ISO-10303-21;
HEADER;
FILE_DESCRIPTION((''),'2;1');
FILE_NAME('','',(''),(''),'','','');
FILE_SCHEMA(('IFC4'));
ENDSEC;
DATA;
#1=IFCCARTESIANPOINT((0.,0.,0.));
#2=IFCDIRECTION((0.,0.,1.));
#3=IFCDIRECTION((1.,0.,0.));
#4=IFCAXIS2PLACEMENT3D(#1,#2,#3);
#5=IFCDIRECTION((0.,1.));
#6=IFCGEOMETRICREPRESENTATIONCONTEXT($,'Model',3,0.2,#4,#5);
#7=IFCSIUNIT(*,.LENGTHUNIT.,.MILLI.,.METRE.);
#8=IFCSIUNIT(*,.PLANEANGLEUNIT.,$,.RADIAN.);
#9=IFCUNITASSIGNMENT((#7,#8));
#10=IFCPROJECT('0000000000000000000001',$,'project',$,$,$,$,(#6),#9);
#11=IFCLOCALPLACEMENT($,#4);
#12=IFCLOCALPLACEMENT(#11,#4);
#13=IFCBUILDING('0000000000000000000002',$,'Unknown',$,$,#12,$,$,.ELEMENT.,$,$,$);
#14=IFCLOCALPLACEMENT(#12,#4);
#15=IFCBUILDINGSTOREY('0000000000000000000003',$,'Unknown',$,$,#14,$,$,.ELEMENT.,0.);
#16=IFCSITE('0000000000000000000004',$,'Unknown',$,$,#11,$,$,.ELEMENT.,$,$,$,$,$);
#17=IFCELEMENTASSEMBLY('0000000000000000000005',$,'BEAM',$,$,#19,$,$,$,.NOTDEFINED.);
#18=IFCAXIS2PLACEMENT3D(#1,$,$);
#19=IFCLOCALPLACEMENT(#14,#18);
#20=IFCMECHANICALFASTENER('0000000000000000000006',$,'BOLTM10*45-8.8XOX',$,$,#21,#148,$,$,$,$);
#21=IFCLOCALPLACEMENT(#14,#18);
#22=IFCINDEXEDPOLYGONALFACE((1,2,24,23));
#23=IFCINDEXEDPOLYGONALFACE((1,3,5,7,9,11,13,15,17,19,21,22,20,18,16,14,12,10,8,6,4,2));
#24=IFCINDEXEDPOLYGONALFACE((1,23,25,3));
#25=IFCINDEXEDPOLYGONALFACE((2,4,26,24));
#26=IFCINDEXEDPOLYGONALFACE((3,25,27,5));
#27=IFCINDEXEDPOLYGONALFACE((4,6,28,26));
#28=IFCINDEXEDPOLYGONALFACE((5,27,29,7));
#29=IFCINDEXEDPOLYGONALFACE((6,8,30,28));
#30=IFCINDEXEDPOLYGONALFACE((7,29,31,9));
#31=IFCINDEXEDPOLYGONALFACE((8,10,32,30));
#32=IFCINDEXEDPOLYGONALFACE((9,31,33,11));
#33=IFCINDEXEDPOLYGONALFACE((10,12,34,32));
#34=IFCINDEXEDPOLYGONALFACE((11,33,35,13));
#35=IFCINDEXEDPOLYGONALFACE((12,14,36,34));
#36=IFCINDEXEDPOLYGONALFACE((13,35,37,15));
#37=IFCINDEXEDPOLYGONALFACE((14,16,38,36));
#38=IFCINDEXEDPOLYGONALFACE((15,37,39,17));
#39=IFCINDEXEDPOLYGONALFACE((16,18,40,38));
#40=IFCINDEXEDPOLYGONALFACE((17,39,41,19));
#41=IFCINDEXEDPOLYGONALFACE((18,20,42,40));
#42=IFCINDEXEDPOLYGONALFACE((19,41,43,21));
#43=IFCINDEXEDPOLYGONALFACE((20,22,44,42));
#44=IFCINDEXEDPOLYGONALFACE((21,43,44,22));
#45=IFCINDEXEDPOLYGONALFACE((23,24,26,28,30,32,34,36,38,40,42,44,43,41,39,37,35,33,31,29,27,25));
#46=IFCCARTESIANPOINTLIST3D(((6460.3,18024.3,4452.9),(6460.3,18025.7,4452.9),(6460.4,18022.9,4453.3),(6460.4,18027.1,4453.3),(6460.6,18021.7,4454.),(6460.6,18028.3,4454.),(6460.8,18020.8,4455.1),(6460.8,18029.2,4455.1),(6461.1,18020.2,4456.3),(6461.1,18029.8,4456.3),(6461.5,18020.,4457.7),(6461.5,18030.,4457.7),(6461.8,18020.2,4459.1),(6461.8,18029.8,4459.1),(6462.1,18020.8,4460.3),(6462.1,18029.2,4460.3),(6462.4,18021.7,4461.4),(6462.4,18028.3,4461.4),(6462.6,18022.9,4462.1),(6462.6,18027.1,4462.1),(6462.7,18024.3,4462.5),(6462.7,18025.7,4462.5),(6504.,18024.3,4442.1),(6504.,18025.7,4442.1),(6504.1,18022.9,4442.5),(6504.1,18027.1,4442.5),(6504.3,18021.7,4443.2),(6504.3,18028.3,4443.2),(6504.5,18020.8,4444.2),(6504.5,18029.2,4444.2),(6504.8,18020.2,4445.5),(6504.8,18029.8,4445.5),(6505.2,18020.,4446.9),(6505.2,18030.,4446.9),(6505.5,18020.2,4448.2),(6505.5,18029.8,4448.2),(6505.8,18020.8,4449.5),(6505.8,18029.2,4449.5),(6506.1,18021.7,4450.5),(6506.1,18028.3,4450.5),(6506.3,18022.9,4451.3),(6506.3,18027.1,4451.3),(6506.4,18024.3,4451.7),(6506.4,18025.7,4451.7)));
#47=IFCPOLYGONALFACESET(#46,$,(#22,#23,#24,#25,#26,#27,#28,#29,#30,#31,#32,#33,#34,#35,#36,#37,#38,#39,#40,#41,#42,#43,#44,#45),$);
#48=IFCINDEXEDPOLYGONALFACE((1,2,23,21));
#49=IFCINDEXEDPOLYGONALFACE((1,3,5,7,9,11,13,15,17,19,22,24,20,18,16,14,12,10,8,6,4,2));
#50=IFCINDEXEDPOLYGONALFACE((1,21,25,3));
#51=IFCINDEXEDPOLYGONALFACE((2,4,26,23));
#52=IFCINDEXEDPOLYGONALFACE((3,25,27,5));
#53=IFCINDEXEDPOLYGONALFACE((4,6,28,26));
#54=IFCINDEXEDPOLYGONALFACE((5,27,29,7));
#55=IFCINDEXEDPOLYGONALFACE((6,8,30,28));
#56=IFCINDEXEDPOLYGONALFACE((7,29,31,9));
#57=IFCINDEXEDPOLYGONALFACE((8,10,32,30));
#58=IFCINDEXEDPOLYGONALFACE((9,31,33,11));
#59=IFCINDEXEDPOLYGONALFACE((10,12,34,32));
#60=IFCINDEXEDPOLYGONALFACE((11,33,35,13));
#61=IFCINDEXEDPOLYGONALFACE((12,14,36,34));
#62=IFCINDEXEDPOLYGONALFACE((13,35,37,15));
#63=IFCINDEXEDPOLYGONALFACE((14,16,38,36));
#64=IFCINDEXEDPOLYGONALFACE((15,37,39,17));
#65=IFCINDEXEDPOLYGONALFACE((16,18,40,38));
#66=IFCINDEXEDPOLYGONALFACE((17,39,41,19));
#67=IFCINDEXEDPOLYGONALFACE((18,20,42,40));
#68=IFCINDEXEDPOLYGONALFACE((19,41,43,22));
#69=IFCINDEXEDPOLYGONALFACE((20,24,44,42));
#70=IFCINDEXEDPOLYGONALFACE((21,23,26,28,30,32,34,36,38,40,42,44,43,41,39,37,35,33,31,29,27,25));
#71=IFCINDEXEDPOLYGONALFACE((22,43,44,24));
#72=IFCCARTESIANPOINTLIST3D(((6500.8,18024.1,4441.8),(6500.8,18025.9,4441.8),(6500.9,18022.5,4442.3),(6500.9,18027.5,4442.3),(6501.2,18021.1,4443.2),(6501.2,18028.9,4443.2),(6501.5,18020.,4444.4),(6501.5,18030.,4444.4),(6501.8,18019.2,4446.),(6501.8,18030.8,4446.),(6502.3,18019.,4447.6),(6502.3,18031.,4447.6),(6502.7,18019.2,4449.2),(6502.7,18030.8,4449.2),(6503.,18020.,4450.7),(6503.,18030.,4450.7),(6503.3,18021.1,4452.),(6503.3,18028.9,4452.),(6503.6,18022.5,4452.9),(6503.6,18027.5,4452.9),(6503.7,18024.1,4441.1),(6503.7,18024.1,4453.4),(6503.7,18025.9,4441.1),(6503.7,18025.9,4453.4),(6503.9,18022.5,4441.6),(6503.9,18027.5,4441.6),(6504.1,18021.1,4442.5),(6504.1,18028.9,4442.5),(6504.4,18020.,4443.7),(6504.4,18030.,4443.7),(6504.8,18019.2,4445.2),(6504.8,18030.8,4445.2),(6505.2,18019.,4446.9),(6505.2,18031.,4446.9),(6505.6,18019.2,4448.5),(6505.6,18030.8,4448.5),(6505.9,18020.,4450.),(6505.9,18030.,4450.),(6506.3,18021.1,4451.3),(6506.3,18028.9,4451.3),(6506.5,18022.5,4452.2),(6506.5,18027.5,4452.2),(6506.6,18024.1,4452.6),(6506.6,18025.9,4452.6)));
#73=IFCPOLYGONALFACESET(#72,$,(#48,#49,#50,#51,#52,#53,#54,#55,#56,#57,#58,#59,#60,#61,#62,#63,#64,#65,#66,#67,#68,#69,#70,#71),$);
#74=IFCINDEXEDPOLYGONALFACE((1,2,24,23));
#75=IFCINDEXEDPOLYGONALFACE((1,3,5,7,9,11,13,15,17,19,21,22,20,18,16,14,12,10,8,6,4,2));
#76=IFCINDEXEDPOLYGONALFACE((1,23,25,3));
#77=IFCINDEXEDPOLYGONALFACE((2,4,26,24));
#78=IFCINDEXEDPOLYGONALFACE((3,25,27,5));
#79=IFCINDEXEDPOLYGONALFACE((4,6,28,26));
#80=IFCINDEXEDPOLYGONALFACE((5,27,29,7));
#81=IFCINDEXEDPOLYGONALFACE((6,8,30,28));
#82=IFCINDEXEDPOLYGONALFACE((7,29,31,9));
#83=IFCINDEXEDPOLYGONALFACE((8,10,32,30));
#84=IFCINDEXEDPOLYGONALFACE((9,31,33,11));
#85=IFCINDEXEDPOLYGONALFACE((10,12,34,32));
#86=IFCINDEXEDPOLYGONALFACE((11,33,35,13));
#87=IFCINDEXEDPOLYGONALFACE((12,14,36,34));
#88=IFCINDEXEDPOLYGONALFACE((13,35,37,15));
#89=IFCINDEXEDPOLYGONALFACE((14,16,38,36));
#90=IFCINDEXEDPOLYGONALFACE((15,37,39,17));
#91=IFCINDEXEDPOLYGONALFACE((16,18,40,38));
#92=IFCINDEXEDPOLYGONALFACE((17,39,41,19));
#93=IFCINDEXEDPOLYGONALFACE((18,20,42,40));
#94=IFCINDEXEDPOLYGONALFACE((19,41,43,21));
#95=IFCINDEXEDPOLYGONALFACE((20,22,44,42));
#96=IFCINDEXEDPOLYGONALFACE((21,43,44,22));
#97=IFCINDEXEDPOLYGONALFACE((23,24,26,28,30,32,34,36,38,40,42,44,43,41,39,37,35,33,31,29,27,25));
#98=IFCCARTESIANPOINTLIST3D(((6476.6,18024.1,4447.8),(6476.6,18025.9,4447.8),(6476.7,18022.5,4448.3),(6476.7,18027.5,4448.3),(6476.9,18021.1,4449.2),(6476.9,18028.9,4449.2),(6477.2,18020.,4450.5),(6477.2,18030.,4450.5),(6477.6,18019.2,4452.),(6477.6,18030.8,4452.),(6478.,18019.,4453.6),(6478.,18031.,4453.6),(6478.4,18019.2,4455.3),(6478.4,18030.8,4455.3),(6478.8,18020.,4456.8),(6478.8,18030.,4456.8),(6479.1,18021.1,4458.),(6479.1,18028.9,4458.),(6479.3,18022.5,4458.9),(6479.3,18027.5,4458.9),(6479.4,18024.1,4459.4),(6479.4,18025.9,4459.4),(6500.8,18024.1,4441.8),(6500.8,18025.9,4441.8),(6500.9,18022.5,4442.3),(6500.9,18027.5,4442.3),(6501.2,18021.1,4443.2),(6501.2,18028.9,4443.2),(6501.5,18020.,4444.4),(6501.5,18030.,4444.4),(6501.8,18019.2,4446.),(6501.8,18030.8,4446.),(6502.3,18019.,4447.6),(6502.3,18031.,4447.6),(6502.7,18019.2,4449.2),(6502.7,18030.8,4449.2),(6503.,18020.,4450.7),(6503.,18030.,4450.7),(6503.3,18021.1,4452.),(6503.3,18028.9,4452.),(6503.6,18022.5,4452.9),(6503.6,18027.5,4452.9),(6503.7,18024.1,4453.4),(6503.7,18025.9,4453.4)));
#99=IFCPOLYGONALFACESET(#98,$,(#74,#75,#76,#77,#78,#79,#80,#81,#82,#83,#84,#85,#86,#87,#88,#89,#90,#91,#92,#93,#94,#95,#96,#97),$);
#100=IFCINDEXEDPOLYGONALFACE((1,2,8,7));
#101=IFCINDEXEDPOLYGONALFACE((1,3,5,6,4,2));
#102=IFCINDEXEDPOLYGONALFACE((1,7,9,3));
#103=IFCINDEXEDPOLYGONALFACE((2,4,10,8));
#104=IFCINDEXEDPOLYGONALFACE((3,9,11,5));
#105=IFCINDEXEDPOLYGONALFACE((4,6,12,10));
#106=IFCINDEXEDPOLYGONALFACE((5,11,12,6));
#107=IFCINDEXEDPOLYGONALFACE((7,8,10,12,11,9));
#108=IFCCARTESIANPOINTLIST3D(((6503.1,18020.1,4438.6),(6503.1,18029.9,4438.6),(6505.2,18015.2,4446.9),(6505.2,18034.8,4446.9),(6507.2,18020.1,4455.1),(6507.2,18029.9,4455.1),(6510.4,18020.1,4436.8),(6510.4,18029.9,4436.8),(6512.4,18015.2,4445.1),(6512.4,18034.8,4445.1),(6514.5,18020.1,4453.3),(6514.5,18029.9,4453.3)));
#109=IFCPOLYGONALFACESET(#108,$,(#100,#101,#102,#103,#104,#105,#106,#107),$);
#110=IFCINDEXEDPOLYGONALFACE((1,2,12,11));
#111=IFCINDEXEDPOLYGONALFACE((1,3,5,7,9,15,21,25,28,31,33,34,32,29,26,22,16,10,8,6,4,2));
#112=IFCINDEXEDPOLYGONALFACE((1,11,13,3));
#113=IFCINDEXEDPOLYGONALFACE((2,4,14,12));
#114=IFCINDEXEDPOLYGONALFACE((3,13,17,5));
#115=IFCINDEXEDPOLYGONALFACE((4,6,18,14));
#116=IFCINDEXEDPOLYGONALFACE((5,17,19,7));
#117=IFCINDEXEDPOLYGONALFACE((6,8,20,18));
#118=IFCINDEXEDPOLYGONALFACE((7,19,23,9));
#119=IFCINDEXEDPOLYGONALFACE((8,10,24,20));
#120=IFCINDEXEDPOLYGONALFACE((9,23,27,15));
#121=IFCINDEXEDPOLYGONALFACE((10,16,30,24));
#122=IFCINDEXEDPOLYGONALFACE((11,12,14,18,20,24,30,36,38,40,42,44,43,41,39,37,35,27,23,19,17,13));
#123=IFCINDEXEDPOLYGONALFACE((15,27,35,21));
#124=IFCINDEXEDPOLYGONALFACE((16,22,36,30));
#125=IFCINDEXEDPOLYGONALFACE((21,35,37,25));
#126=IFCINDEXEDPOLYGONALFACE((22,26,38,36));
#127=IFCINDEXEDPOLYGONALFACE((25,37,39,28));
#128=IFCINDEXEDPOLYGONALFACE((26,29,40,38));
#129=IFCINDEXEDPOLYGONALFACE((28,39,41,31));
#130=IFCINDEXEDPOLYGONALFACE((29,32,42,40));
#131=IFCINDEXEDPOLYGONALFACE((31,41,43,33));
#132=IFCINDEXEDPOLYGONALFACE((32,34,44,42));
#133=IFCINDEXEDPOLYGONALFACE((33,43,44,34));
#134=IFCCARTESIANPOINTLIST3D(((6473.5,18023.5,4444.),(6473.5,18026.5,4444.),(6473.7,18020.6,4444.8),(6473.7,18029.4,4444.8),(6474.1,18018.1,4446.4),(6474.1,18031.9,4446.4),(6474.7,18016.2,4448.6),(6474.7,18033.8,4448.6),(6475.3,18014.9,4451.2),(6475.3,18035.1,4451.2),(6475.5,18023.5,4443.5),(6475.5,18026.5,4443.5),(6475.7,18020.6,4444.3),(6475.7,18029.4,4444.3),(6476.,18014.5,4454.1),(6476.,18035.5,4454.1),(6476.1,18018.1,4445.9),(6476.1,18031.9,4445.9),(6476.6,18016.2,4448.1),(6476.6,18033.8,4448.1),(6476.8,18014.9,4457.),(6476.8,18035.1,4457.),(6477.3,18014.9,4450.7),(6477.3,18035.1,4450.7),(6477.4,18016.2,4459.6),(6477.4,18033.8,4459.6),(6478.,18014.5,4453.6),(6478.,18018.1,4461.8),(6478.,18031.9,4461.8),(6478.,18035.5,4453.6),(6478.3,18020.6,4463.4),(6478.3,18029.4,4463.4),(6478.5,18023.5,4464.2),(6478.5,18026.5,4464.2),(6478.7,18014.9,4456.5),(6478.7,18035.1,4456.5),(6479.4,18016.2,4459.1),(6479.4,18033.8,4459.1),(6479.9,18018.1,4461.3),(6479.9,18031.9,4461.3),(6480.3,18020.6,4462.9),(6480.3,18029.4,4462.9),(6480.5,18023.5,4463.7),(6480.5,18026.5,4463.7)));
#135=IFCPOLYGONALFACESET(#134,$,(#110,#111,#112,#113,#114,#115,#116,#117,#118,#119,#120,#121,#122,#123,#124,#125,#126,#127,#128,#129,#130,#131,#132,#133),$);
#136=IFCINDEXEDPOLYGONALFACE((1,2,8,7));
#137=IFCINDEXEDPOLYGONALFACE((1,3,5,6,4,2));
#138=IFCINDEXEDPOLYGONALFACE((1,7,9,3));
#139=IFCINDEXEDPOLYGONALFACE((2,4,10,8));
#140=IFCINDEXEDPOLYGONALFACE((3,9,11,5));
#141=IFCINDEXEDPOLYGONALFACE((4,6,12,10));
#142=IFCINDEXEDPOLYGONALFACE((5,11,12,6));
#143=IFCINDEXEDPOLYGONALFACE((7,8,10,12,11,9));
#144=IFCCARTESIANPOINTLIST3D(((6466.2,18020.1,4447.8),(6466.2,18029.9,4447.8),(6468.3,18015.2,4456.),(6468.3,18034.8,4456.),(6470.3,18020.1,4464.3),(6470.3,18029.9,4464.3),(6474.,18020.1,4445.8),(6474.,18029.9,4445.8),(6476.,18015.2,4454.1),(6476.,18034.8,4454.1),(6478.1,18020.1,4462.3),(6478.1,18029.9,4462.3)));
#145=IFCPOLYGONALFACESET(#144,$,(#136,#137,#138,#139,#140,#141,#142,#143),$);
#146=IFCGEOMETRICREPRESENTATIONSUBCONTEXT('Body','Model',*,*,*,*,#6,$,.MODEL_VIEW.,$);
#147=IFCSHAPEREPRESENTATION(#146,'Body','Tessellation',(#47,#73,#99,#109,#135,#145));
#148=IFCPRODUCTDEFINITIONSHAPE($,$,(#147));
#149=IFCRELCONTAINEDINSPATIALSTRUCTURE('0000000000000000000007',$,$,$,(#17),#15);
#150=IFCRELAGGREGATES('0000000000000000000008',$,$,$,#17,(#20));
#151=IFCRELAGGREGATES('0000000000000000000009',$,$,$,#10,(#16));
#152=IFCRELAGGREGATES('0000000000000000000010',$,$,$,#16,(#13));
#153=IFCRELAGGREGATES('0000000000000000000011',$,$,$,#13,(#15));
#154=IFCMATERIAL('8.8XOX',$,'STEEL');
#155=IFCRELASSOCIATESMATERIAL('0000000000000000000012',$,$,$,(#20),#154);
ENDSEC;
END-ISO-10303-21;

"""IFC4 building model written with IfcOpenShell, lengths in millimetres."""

from ifc_helpers import new_model, si_unit, direction, frame, origin_with_axes, place, context, subcontext, project, spatial, line, arc, indexed_curve, outline, extrude, source, transform, mapped, material, element, aggregate, save


model = new_model("IFC4")

# Units and contexts
model_context = context("Model", 3, precision=0.2, world=origin_with_axes(), true_north=direction((0.0, 1.0)))
body_context = subcontext(model_context, "Body", "Model", "MODEL_VIEW")
ifc_project = project(units=[si_unit("LENGTHUNIT", "METRE", prefix="MILLI"), si_unit("PLANEANGLEUNIT", "RADIAN")], contexts=[model_context])

# Site, building, storey
site_placement = place(None, origin_with_axes())
site = spatial("IfcSite", under=ifc_project, at=site_placement, Name="Unknown", CompositionType="ELEMENT")
building_placement = place(site_placement, origin_with_axes())
building = spatial("IfcBuilding", under=site, at=building_placement, Name="Unknown", CompositionType="ELEMENT")
storey_placement = place(building_placement, origin_with_axes())
storey = spatial("IfcBuildingStorey", under=building, at=storey_placement, Name="Unknown", CompositionType="ELEMENT", Elevation=0.0)

# Shared definitions
ifc_material_1 = material(Name="8.8XOX", Category="STEEL")

# Element assembly, mechanical fastener
shared_shape_1 = source(origin_with_axes(), body_context, "Body", "SweptSolid", [
    extrude(outline(indexed_curve([(5.0, 0.0), (0.0, 5.0), (-5.0, 0.0), (0.0, -5.0)], segments=[arc(1, 2, 3), arc(3, 4, 1)])), frame((0.0, 0.0, 3.8), z_axis=(0.0, 0.0, -1.0), x_axis=(0.0, 1.0, 0.0)), (0.0, 0.0, 1.0), 45.0),
    extrude(outline(indexed_curve([(6.0, 0.0), (0.0, 6.0), (-6.0, 0.0), (0.0, -6.0)], segments=[arc(1, 2, 3), arc(3, 4, 1)])), frame((0.0, 0.0, 3.8), z_axis=(0.0, 0.0, -1.0), x_axis=(0.0, 1.0, 0.0)), (0.0, 0.0, 1.0), 3.0),
    extrude(outline(indexed_curve([(6.0, 0.0), (0.0, 6.0), (-6.0, 0.0), (0.0, -6.0)], segments=[arc(1, 2, 3), arc(3, 4, 1)])), frame((0.0, 0.0, 0.8), z_axis=(0.0, 0.0, -1.0), x_axis=(0.0, 1.0, 0.0)), (0.0, 0.0, 1.0), 25.0),
    extrude(outline(indexed_curve([(9.8, 0.0), (4.9, 8.5), (-4.9, 8.5), (-9.8, 0.0), (-4.9, -8.5), (4.9, -8.5)], segments=[line(1, 2, 3, 4, 5, 6, 1)])), frame((0.0, 0.0, 11.2), z_axis=(0.0, 0.0, -1.0), x_axis=(0.0, 1.0, 0.0)), (0.0, 0.0, 1.0), 7.5),
    extrude(outline(indexed_curve([(10.5, 0.0), (0.0, 10.5), (-10.5, 0.0), (0.0, -10.5)], segments=[arc(1, 2, 3), arc(3, 4, 1)])), frame((0.0, 0.0, -24.2), z_axis=(0.0, 0.0, -1.0), x_axis=(0.0, 1.0, 0.0)), (0.0, 0.0, 1.0), 2.0),
    extrude(outline(indexed_curve([(9.8, 0.0), (4.9, 8.5), (-4.9, 8.5), (-9.8, 0.0), (-4.9, -8.5), (4.9, -8.5)], segments=[line(1, 2, 3, 4, 5, 6, 1)])), frame((0.0, 0.0, -26.2), z_axis=(0.0, 0.0, -1.0), x_axis=(0.0, 1.0, 0.0)), (0.0, 0.0, 1.0), 8.0),
])
assembly_1_placement = place(storey_placement, frame((6491.3, 18000.0, 4455.5), z_axis=(0.970613, 0.0, -0.240648), x_axis=(0.0, 1.0, 0.0)))
assembly_1 = element("IfcElementAssembly", 1, at=assembly_1_placement, inside=storey, Name="BEAM", PredefinedType="NOTDEFINED")
mechanical_fastener_1_placement = place(assembly_1_placement, frame((25.0, -5.0, 11.8), z_axis=(0.0, 0.0, 1.0), x_axis=(0.0, 1.0, 0.0)))
mechanical_fastener_1 = element("IfcMechanicalFastener", 2, at=mechanical_fastener_1_placement, material=ifc_material_1, Name="BOLTM10*45-8.8XOX", context=body_context, shape_type="MappedRepresentation", body=[
    mapped(shared_shape_1, transform((0.0, 0.0, 0.0))),
])
aggregate(assembly_1, [mechanical_fastener_1])

save(model, "model.ifc")
